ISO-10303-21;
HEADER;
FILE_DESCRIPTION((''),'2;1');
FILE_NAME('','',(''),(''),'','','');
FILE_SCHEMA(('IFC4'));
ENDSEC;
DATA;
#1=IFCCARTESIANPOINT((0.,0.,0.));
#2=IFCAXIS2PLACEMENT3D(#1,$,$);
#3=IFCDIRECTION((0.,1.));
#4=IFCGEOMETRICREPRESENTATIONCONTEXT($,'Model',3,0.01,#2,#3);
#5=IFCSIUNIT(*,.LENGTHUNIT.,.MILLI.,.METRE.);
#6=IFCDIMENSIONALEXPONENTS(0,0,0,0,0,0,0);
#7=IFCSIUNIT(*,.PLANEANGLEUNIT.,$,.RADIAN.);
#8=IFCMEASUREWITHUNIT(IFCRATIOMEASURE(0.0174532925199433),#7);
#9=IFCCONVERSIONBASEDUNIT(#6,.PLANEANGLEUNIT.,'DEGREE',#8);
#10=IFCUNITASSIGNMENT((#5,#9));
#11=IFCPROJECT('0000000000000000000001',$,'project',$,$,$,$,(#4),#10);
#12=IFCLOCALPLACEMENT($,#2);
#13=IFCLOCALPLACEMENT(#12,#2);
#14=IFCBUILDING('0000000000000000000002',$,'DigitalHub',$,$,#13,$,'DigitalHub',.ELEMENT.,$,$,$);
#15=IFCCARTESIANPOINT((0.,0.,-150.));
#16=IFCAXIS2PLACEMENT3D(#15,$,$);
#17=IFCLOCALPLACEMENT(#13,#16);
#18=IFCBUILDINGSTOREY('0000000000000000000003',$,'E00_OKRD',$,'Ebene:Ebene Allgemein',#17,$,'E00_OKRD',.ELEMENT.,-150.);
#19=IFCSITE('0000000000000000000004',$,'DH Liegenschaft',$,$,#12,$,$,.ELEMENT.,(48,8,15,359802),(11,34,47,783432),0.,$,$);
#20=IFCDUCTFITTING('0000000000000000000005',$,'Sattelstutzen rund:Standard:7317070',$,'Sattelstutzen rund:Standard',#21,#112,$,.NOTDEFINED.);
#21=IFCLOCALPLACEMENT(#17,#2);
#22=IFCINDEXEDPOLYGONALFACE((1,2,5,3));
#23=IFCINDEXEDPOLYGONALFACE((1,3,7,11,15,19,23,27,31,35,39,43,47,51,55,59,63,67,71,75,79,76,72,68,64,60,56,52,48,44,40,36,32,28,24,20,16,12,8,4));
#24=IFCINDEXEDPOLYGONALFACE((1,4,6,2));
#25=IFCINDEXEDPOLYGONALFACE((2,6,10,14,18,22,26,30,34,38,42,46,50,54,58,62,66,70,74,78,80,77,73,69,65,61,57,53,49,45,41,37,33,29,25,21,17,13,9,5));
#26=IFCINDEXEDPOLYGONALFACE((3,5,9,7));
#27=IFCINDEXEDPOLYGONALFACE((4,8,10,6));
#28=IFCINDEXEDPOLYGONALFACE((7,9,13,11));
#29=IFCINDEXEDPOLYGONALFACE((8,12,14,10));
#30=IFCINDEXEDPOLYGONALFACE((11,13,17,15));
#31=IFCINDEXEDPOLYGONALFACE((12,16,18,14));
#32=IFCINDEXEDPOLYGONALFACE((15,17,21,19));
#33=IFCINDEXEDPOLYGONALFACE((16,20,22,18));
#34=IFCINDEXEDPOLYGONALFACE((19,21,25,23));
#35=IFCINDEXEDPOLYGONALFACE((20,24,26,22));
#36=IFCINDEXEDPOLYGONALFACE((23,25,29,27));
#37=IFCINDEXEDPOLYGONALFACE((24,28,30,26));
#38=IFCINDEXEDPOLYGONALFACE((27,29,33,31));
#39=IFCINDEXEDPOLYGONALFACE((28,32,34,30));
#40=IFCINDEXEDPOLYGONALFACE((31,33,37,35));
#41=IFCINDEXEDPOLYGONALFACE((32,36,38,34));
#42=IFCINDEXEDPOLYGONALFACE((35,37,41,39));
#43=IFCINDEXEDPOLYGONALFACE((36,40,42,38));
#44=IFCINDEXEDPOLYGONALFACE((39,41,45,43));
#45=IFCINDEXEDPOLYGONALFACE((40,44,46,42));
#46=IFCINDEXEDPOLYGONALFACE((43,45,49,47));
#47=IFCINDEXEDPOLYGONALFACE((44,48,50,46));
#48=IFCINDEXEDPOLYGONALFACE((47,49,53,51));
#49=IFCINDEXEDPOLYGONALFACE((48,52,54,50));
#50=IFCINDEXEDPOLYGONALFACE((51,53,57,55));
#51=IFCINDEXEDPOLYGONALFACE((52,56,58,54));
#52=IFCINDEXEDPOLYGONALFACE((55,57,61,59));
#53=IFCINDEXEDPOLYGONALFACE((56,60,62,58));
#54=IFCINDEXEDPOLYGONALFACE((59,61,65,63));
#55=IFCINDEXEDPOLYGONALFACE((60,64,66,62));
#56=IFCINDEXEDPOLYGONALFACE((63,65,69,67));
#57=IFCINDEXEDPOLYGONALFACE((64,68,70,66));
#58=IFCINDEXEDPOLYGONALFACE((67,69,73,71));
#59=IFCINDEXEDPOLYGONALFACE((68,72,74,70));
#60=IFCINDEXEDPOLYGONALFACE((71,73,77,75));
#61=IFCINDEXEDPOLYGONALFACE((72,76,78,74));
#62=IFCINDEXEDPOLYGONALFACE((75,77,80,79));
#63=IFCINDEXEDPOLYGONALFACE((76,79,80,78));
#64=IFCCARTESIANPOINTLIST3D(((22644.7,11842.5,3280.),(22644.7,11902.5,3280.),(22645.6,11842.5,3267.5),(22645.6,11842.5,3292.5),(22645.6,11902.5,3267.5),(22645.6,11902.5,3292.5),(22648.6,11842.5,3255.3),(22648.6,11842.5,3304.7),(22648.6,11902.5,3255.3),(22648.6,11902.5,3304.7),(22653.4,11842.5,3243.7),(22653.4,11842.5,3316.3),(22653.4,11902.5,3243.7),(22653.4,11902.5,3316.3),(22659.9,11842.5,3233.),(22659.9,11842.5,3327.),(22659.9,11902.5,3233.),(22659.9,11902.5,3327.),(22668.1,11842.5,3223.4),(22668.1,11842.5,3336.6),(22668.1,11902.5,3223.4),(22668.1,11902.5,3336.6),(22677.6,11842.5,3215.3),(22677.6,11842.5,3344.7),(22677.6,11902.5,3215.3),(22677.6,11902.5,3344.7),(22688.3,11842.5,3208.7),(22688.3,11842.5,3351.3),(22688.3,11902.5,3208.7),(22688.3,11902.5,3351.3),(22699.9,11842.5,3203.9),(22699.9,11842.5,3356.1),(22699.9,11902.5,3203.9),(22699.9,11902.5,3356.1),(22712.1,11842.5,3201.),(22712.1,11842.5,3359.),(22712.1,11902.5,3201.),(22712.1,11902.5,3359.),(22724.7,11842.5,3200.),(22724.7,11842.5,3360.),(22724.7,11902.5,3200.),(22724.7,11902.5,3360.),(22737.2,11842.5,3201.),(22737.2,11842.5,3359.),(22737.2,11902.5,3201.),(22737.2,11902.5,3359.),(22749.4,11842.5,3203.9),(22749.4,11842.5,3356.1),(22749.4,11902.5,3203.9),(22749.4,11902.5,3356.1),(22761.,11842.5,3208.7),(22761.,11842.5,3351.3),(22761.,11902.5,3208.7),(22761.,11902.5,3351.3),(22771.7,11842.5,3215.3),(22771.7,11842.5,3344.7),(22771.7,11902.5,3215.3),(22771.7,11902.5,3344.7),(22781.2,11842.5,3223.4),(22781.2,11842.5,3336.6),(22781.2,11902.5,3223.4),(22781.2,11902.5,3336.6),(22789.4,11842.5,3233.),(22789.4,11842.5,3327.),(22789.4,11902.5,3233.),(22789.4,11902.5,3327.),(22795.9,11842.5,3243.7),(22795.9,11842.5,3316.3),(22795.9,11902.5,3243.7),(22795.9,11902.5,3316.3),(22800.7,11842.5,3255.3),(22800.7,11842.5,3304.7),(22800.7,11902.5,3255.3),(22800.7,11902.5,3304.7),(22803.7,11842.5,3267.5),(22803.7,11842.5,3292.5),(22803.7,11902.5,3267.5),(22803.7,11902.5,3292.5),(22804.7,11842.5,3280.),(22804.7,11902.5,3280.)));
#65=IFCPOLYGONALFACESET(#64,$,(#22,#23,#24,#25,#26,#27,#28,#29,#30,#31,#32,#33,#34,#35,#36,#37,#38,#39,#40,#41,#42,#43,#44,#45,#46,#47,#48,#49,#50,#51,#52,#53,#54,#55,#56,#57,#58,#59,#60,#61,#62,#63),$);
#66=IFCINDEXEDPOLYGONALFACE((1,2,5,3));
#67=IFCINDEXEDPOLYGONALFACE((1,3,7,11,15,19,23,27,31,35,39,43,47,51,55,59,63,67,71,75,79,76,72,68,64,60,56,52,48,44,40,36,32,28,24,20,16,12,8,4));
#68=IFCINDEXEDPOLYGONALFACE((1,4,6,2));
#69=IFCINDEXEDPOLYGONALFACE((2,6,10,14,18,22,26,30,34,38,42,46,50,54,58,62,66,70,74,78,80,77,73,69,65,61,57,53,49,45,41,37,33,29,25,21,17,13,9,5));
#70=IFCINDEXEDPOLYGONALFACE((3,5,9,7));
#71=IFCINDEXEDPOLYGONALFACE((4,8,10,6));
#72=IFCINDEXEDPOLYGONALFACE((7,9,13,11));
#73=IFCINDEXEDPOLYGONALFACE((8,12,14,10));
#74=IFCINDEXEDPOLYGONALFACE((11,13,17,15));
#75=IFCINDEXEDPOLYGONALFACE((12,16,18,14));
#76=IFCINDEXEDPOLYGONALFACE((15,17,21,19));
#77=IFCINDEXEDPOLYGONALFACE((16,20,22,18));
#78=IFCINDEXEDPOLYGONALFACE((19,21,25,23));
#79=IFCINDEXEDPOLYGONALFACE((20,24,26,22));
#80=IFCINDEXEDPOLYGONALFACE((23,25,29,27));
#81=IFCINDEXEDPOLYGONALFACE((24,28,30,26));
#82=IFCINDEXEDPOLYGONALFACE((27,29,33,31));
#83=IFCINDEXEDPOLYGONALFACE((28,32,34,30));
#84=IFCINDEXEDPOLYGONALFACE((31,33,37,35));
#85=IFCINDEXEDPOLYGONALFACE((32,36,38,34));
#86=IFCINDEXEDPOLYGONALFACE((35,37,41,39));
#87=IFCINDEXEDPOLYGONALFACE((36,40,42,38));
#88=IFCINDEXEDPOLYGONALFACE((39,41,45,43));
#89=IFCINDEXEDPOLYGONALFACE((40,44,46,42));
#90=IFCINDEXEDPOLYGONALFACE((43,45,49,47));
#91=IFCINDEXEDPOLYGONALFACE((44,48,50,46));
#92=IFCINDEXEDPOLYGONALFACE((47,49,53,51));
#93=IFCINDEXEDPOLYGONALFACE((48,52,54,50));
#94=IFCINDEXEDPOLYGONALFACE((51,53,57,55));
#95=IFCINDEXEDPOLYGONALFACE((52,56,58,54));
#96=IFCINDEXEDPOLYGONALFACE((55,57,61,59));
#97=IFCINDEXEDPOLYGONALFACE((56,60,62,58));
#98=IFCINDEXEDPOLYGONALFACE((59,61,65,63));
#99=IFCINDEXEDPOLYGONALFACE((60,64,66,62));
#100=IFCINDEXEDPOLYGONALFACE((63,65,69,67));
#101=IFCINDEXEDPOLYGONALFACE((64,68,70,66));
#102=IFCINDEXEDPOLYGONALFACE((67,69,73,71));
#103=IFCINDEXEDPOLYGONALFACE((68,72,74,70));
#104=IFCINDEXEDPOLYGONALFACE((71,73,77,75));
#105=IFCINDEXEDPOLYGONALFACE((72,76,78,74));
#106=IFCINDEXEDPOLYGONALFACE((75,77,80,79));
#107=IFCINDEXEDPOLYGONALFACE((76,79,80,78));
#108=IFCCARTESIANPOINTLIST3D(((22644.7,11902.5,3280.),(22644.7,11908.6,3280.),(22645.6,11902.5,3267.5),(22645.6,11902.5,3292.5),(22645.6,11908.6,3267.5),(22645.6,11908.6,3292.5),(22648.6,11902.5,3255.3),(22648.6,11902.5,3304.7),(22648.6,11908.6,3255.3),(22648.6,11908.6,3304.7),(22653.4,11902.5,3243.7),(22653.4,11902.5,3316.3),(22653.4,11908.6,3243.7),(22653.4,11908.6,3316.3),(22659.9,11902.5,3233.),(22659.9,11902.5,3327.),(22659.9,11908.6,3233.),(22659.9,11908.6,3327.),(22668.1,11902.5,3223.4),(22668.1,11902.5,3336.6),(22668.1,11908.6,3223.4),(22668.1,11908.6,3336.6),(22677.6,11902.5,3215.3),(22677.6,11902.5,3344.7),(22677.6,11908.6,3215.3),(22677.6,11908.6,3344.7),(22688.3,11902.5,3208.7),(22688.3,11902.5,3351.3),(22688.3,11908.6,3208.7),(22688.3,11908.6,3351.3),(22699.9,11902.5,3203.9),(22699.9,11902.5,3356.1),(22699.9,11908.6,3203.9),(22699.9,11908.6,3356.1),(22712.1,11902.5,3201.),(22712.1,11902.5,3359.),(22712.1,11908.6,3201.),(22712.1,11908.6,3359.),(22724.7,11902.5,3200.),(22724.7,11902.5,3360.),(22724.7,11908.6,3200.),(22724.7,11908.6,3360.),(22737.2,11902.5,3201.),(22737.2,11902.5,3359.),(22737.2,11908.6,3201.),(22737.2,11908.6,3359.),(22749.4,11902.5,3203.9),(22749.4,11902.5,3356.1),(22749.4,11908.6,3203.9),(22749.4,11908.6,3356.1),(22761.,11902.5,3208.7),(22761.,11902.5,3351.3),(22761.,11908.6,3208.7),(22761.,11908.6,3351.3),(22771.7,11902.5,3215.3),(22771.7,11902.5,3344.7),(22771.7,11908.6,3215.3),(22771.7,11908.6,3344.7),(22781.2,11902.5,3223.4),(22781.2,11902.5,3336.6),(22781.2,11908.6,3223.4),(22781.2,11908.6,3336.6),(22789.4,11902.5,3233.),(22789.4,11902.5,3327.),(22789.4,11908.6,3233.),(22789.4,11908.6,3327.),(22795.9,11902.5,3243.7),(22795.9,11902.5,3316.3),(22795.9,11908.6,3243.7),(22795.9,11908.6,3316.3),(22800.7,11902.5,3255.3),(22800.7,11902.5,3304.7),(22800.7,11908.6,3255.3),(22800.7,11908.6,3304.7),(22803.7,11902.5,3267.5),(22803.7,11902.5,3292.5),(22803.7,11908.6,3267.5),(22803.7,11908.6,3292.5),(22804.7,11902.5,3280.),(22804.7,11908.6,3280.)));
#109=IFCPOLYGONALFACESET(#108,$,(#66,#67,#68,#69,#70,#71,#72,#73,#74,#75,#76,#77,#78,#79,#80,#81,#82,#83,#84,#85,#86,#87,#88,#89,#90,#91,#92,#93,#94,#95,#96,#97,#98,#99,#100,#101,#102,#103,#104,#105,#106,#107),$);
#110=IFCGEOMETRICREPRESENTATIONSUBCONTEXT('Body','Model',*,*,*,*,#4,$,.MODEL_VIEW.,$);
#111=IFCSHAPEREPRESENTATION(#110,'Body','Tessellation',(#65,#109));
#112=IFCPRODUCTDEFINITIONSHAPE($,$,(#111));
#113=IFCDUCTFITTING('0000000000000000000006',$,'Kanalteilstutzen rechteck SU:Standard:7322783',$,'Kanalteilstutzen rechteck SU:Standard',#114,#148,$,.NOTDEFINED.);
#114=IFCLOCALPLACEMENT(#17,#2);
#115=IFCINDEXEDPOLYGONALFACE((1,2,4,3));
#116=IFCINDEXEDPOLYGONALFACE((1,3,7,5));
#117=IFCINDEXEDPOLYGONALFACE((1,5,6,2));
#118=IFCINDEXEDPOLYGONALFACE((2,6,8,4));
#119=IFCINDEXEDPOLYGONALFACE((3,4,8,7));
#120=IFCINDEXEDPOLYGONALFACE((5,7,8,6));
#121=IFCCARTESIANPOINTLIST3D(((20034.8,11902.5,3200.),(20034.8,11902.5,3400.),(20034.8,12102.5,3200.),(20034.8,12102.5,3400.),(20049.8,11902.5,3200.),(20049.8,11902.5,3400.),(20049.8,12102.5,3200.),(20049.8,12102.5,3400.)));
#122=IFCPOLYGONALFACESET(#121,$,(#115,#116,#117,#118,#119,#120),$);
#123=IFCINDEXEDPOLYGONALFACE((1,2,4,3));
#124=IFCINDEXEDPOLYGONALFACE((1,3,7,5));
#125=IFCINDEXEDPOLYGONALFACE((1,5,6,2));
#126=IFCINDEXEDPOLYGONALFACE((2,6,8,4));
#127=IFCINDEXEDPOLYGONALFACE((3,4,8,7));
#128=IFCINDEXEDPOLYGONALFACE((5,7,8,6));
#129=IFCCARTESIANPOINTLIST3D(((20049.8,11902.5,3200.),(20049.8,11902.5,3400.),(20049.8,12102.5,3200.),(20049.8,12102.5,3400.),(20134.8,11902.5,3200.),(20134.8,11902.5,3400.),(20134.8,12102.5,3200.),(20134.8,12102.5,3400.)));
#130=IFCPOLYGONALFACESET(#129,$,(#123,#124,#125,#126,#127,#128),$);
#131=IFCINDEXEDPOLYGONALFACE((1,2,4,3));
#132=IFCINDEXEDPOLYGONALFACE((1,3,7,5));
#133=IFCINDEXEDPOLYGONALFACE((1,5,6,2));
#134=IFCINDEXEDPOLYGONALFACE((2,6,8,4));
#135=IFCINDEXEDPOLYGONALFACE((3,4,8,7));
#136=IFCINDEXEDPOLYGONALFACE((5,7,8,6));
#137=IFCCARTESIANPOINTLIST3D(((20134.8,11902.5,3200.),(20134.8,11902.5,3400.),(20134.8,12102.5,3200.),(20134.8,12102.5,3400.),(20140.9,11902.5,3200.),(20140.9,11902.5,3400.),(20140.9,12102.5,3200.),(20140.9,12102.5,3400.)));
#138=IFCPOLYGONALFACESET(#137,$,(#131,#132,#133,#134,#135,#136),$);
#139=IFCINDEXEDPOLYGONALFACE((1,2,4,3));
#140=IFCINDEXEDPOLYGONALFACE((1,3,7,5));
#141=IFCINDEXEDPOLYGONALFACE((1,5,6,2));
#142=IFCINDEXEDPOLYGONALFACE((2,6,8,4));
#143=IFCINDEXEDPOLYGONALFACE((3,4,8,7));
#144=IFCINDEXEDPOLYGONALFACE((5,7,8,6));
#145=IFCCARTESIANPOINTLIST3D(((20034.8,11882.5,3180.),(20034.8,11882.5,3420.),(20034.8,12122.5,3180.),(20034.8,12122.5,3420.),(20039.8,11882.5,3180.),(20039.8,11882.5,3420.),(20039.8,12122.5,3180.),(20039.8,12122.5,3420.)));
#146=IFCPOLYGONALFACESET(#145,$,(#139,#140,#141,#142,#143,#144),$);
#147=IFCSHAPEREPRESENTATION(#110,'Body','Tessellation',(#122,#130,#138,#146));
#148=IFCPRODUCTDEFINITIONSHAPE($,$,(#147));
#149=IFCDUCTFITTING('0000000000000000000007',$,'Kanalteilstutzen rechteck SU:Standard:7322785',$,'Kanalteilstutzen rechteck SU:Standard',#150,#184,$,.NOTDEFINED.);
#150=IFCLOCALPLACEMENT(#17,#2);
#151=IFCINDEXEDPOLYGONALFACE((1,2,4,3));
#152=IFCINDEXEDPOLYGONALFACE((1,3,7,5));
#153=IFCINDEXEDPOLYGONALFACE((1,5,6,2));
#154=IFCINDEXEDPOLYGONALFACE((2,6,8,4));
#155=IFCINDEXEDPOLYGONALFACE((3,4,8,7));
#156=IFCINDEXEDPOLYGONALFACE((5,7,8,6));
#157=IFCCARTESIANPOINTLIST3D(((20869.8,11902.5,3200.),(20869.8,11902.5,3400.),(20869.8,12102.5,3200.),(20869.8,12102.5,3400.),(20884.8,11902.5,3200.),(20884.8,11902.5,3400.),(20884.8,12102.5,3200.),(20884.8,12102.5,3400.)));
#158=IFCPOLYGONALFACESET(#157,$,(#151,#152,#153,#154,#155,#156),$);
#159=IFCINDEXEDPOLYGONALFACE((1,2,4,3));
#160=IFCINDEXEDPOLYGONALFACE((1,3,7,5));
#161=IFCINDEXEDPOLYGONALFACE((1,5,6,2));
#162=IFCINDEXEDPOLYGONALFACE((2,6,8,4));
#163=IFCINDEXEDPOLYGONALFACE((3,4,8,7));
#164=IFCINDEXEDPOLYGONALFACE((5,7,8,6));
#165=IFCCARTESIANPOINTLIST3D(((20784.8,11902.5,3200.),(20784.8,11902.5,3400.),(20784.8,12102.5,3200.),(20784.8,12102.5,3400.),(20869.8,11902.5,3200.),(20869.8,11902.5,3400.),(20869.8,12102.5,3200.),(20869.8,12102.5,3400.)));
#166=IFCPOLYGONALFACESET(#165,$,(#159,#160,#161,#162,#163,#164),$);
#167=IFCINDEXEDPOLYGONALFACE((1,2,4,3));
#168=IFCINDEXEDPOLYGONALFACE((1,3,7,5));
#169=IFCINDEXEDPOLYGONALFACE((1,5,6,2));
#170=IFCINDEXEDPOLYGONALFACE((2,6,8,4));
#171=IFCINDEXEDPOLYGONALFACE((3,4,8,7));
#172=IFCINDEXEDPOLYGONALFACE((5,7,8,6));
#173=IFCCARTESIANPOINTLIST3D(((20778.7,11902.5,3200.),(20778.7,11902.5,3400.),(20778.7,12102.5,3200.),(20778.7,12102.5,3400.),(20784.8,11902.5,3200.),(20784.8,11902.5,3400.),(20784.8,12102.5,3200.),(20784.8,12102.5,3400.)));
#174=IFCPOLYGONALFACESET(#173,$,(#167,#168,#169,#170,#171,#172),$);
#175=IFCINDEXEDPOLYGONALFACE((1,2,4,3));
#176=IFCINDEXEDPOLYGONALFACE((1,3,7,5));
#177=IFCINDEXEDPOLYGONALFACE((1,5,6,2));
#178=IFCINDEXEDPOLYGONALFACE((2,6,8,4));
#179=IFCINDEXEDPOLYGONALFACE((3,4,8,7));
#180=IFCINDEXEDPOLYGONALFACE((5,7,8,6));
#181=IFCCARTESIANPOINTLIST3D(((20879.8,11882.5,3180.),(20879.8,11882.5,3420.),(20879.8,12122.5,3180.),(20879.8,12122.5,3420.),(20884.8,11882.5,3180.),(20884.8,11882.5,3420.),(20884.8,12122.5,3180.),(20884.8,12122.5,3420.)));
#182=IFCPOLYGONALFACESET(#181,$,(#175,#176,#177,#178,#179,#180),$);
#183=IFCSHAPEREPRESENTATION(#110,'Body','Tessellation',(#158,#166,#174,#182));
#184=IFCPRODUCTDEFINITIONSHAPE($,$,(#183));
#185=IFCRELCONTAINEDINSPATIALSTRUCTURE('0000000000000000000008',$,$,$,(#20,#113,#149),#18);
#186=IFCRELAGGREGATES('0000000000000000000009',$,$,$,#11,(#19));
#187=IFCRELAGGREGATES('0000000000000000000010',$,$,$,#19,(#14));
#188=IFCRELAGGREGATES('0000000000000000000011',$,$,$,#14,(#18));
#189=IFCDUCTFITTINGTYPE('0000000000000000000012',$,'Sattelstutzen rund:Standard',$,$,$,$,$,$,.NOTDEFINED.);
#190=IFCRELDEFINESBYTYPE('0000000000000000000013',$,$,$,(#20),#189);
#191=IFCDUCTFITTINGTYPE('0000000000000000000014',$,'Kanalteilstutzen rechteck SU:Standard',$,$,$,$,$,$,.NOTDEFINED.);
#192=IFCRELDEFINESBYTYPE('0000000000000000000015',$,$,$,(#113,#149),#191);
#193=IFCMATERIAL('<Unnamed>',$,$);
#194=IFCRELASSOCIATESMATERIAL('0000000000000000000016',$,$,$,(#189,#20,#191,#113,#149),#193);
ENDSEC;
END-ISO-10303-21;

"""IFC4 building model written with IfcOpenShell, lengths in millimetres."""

from ifc_helpers import new_model, entity, si_unit, converted_unit, direction, frame, origin, place, context, subcontext, project, spatial, indexed_curve, outline, extrude, source, transform, mapped, material, type_object, type_shapes, element, save


model = new_model("IFC4")

# Units and contexts
model_context = context("Model", 3, precision=0.01, world=origin(), true_north=direction((0.0, 1.0)))
body_context = subcontext(model_context, "Body", "Model", "MODEL_VIEW")
ifc_project = project(units=[si_unit("LENGTHUNIT", "METRE", prefix="MILLI"), converted_unit("PLANEANGLEUNIT", "DEGREE", entity("IfcRatioMeasure", 0.0174532925199433), si_unit("PLANEANGLEUNIT", "RADIAN"), dimensions=[0, 0, 0, 0, 0, 0, 0])], contexts=[model_context])

# Site, building, storey
site_placement = place(None, origin())
site = spatial("IfcSite", under=ifc_project, at=site_placement, Name="DH Liegenschaft", CompositionType="ELEMENT", RefLatitude=(48, 8, 15, 359802), RefLongitude=(11, 34, 47, 783432), RefElevation=0.0)
building_placement = place(site_placement, origin())
building = spatial("IfcBuilding", under=site, at=building_placement, Name="DigitalHub", LongName="DigitalHub", CompositionType="ELEMENT")
storey_placement = place(building_placement, frame((0.0, 0.0, -150.0)))
storey = spatial("IfcBuildingStorey", under=building, at=storey_placement, Name="E00_OKRD", ObjectType="Ebene:Ebene Allgemein", LongName="E00_OKRD", CompositionType="ELEMENT", Elevation=-150.0)

# Shared definitions
ifc_material_1 = material(Name="<Unnamed>")

# Duct fittings
duct_fitting_type_1 = type_object("IfcDuctFittingType", Name="Sattelstutzen rund:Standard", PredefinedType="NOTDEFINED", material=ifc_material_1)
shared_shape_1 = source(origin(), body_context, "Body", "SweptSolid", [
    extrude(outline(indexed_curve([(0.0, -80.0), (12.5, -79.0), (24.7, -76.1), (36.3, -71.3), (47.0, -64.7), (56.6, -56.6), (64.7, -47.0), (71.3, -36.3), (76.1, -24.7), (79.0, -12.5), (80.0, 0.0), (79.0, 12.5), (76.1, 24.7), (71.3, 36.3), (64.7, 47.0), (56.6, 56.6), (47.0, 64.7), (36.3, 71.3), (24.7, 76.1), (12.5, 79.0), (0.0, 80.0), (-12.5, 79.0), (-24.7, 76.1), (-36.3, 71.3), (-47.0, 64.7), (-56.6, 56.6), (-64.7, 47.0), (-71.3, 36.3), (-76.1, 24.7), (-79.0, 12.5), (-80.0, 0.0), (-79.0, -12.5), (-76.1, -24.7), (-71.3, -36.3), (-64.7, -47.0), (-56.6, -56.6), (-47.0, -64.7), (-36.3, -71.3), (-24.7, -76.1), (-12.5, -79.0), (0.0, -80.0)], self_intersect=False)), frame((0.0, 0.0, 0.0), z_axis=(1.0, 0.0, 0.0), x_axis=(0.0, -1.0, 0.0)), (0.0, 0.0, 1.0), 60.0),
    extrude(outline(indexed_curve([(0.0, -80.0), (12.5, -79.0), (24.7, -76.1), (36.3, -71.3), (47.0, -64.7), (56.6, -56.6), (64.7, -47.0), (71.3, -36.3), (76.1, -24.7), (79.0, -12.5), (80.0, 0.0), (79.0, 12.5), (76.1, 24.7), (71.3, 36.3), (64.7, 47.0), (56.6, 56.6), (47.0, 64.7), (36.3, 71.3), (24.7, 76.1), (12.5, 79.0), (0.0, 80.0), (-12.5, 79.0), (-24.7, 76.1), (-36.3, 71.3), (-47.0, 64.7), (-56.6, 56.6), (-64.7, 47.0), (-71.3, 36.3), (-76.1, 24.7), (-79.0, 12.5), (-80.0, 0.0), (-79.0, -12.5), (-76.1, -24.7), (-71.3, -36.3), (-64.7, -47.0), (-56.6, -56.6), (-47.0, -64.7), (-36.3, -71.3), (-24.7, -76.1), (-12.5, -79.0), (0.0, -80.0)], self_intersect=False)), frame((-6.1, 0.0, 0.0), z_axis=(1.0, 0.0, 0.0), x_axis=(0.0, -1.0, 0.0)), (0.0, 0.0, 1.0), 6.1),
])
type_shapes(duct_fitting_type_1, [shared_shape_1])
duct_fitting_1_placement = place(storey_placement, frame((22724.7, 11902.5, 3280.0), z_axis=(0.0, 0.0, -1.0), x_axis=(0.0, -1.0, 0.0)))
element("IfcDuctFitting", 1, at=duct_fitting_1_placement, inside=storey, type_object=duct_fitting_type_1, material=ifc_material_1, Name="Sattelstutzen rund:Standard:7317070", ObjectType="Sattelstutzen rund:Standard", PredefinedType="NOTDEFINED", context=body_context, shape_type="MappedRepresentation", body=[
    mapped(shared_shape_1, transform((0.0, 0.0, 0.0), scale=1.0)),
])
duct_fitting_type_2 = type_object("IfcDuctFittingType", Name="Kanalteilstutzen rechteck SU:Standard", PredefinedType="NOTDEFINED", material=ifc_material_1)
shared_shape_2 = source(origin(), body_context, "Body", "SweptSolid", [
    extrude(outline(indexed_curve([(-7.5, -100.0), (7.5, -100.0), (7.5, 100.0), (-7.5, 100.0), (-7.5, -100.0)], self_intersect=False)), frame((92.5, 0.0, -100.0)), (0.0, 0.0, 1.0), 200.0),
    extrude(outline(indexed_curve([(-42.5, -100.0), (42.5, -100.0), (42.5, 100.0), (-42.5, 100.0), (-42.5, -100.0)], self_intersect=False)), frame((42.5, 0.0, -100.0)), (0.0, 0.0, 1.0), 200.0),
    extrude(outline(indexed_curve([(-3.0, -100.0), (3.0, -100.0), (3.0, 100.0), (-3.0, 100.0), (-3.0, -100.0)], self_intersect=False)), frame((-3.0, 0.0, -100.0)), (0.0, 0.0, 1.0), 200.0),
    extrude(outline(indexed_curve([(-2.5, -120.0), (2.5, -120.0), (2.5, 120.0), (-2.5, 120.0), (-2.5, -120.0)], self_intersect=False)), frame((97.5, 0.0, -120.0)), (0.0, 0.0, 1.0), 240.0),
])
type_shapes(duct_fitting_type_2, [shared_shape_2])
for number, where, z_axis, x_axis, name in (
    (2, (20134.8, 12002.5, 3300.0), (0.0, 0.0, 1.0), (-1.0, 0.0, 0.0), "Kanalteilstutzen rechteck SU:Standard:7322783"),
    (3, (20784.8, 12002.5, 3300.0), (0.0, 0.0, -1.0), (1.0, 0.0, 0.0), "Kanalteilstutzen rechteck SU:Standard:7322785"),
):
    element("IfcDuctFitting", number, at=place(storey_placement, frame(where, z_axis=z_axis, x_axis=x_axis)), inside=storey, type_object=duct_fitting_type_2, material=ifc_material_1, Name=name, ObjectType="Kanalteilstutzen rechteck SU:Standard", PredefinedType="NOTDEFINED", context=body_context, shape_type="MappedRepresentation", body=[
        mapped(shared_shape_2, transform((0.0, 0.0, 0.0), scale=1.0)),
    ])

save(model, "model.ifc")
